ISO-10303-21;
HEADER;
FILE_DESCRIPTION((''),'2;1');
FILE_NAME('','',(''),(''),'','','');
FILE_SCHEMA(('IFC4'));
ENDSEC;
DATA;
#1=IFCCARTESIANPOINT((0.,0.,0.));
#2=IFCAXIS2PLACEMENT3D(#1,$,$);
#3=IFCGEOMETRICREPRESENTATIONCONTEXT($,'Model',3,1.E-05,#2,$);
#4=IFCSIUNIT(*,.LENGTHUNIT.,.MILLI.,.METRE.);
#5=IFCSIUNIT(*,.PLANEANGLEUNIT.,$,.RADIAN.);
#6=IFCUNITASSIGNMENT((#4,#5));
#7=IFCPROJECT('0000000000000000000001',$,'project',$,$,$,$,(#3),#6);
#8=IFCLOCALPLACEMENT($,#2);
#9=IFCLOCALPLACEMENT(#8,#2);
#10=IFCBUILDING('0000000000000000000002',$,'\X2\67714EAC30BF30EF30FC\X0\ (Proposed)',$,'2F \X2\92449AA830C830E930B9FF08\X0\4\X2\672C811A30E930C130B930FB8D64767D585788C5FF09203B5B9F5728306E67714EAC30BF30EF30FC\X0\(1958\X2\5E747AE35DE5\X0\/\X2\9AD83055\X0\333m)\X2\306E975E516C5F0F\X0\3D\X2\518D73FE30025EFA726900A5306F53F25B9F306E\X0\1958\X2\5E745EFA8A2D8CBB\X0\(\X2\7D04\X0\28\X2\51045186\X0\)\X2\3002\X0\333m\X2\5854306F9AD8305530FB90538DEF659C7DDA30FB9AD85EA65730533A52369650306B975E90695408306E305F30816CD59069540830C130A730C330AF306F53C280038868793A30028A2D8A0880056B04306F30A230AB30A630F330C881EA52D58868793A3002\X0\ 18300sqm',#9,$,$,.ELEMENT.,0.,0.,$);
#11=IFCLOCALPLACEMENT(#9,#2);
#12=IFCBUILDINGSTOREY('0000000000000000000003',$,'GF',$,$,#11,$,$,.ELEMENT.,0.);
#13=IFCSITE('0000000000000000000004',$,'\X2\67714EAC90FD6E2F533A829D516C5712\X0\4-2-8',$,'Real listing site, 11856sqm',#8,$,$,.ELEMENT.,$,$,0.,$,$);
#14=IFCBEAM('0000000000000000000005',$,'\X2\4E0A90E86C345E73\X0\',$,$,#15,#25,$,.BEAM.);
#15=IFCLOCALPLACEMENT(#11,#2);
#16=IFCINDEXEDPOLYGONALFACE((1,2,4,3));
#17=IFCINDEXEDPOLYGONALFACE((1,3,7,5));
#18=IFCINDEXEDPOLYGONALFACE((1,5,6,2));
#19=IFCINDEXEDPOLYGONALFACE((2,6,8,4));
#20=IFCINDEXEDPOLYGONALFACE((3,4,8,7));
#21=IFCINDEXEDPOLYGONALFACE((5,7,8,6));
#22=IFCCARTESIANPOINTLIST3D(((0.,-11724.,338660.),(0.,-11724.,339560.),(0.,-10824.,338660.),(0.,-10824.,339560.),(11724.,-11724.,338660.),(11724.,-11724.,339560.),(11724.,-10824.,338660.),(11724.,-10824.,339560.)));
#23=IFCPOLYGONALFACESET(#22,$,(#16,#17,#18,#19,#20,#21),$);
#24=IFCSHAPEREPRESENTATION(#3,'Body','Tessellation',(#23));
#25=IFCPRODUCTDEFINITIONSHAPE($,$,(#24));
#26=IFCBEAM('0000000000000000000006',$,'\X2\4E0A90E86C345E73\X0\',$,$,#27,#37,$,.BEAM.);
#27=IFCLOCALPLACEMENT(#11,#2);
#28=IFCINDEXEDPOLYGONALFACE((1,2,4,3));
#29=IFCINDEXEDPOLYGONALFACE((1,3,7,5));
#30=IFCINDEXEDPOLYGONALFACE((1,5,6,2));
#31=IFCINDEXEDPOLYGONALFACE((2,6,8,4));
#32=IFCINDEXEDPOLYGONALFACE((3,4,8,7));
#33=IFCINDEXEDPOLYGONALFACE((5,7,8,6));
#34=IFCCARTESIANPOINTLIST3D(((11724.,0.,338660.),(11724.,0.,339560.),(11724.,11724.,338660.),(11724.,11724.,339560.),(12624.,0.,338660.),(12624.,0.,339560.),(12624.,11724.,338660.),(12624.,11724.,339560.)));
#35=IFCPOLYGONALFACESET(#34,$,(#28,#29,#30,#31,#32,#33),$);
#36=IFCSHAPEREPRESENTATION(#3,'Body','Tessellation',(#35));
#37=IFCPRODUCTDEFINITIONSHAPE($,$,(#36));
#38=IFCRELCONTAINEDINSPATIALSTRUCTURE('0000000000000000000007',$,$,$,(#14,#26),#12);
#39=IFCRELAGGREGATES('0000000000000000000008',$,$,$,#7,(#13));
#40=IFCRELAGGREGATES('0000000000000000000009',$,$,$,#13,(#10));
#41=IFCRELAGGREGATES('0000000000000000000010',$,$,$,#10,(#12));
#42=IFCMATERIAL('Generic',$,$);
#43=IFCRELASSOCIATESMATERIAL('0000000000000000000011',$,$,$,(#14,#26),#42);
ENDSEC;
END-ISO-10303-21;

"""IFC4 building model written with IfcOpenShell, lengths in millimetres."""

from ifc_helpers import new_model, si_unit, frame, frame_2d, origin, place, context, project, spatial, rectangle, extrude, material, element, save


model = new_model("IFC4")

# Units and contexts
model_context = context("Model", 3, precision=1e-05, world=origin())
ifc_project = project(units=[si_unit("LENGTHUNIT", "METRE", prefix="MILLI"), si_unit("PLANEANGLEUNIT", "RADIAN")], contexts=[model_context])

# Site, building, storey
site_placement = place(None, origin())
site = spatial("IfcSite", under=ifc_project, at=site_placement, Name="東京都港区芝公園4-2-8", ObjectType="Real listing site, 11856sqm", CompositionType="ELEMENT", RefElevation=0.0)
building_placement = place(site_placement, origin())
building = spatial("IfcBuilding", under=site, at=building_placement, Name="東京タワー (Proposed)", ObjectType="2F 鉄骨トラス（4本脚ラチス・赤白塗装）※実在の東京タワー(1958年竣工/高さ333m)の非公式3D再現。建物¥は史実の1958年建設費(約28億円)。333m塔は高さ・道路斜線・高度地区制限に非適合のため法適合チェックは参考表示。設計者欄はアカウント自動表示。 18300sqm", CompositionType="ELEMENT", ElevationOfRefHeight=0.0, ElevationOfTerrain=0.0)
storey_placement = place(building_placement, origin())
storey = spatial("IfcBuildingStorey", under=building, at=storey_placement, Name="GF", CompositionType="ELEMENT", Elevation=0.0)

# Shared definitions
ifc_material = material(Name="Generic")

# Beams
beam_1_placement = place(storey_placement, frame((0.0, -5862.0, 169330.0)))
element("IfcBeam", 1, at=beam_1_placement, inside=storey, material=ifc_material, Name="上部水平", PredefinedType="BEAM", context=model_context, shape_type="SweptSolid", body=[
    extrude(rectangle(XDim=11724.0, YDim=900.0, at=frame_2d((5862.0, 450.0))), frame((0.0, -5862.0, 169330.0)), (0.0, 0.0, 1.0), 900.0),
])
beam_2_placement = place(storey_placement, frame((5862.0, 0.0, 169330.0)))
element("IfcBeam", 2, at=beam_2_placement, inside=storey, material=ifc_material, Name="上部水平", PredefinedType="BEAM", context=model_context, shape_type="SweptSolid", body=[
    extrude(rectangle(XDim=900.0, YDim=11724.0, at=frame_2d((450.0, 5862.0))), frame((5862.0, 0.0, 169330.0)), (0.0, 0.0, 1.0), 900.0),
])

save(model, "model.ifc")
